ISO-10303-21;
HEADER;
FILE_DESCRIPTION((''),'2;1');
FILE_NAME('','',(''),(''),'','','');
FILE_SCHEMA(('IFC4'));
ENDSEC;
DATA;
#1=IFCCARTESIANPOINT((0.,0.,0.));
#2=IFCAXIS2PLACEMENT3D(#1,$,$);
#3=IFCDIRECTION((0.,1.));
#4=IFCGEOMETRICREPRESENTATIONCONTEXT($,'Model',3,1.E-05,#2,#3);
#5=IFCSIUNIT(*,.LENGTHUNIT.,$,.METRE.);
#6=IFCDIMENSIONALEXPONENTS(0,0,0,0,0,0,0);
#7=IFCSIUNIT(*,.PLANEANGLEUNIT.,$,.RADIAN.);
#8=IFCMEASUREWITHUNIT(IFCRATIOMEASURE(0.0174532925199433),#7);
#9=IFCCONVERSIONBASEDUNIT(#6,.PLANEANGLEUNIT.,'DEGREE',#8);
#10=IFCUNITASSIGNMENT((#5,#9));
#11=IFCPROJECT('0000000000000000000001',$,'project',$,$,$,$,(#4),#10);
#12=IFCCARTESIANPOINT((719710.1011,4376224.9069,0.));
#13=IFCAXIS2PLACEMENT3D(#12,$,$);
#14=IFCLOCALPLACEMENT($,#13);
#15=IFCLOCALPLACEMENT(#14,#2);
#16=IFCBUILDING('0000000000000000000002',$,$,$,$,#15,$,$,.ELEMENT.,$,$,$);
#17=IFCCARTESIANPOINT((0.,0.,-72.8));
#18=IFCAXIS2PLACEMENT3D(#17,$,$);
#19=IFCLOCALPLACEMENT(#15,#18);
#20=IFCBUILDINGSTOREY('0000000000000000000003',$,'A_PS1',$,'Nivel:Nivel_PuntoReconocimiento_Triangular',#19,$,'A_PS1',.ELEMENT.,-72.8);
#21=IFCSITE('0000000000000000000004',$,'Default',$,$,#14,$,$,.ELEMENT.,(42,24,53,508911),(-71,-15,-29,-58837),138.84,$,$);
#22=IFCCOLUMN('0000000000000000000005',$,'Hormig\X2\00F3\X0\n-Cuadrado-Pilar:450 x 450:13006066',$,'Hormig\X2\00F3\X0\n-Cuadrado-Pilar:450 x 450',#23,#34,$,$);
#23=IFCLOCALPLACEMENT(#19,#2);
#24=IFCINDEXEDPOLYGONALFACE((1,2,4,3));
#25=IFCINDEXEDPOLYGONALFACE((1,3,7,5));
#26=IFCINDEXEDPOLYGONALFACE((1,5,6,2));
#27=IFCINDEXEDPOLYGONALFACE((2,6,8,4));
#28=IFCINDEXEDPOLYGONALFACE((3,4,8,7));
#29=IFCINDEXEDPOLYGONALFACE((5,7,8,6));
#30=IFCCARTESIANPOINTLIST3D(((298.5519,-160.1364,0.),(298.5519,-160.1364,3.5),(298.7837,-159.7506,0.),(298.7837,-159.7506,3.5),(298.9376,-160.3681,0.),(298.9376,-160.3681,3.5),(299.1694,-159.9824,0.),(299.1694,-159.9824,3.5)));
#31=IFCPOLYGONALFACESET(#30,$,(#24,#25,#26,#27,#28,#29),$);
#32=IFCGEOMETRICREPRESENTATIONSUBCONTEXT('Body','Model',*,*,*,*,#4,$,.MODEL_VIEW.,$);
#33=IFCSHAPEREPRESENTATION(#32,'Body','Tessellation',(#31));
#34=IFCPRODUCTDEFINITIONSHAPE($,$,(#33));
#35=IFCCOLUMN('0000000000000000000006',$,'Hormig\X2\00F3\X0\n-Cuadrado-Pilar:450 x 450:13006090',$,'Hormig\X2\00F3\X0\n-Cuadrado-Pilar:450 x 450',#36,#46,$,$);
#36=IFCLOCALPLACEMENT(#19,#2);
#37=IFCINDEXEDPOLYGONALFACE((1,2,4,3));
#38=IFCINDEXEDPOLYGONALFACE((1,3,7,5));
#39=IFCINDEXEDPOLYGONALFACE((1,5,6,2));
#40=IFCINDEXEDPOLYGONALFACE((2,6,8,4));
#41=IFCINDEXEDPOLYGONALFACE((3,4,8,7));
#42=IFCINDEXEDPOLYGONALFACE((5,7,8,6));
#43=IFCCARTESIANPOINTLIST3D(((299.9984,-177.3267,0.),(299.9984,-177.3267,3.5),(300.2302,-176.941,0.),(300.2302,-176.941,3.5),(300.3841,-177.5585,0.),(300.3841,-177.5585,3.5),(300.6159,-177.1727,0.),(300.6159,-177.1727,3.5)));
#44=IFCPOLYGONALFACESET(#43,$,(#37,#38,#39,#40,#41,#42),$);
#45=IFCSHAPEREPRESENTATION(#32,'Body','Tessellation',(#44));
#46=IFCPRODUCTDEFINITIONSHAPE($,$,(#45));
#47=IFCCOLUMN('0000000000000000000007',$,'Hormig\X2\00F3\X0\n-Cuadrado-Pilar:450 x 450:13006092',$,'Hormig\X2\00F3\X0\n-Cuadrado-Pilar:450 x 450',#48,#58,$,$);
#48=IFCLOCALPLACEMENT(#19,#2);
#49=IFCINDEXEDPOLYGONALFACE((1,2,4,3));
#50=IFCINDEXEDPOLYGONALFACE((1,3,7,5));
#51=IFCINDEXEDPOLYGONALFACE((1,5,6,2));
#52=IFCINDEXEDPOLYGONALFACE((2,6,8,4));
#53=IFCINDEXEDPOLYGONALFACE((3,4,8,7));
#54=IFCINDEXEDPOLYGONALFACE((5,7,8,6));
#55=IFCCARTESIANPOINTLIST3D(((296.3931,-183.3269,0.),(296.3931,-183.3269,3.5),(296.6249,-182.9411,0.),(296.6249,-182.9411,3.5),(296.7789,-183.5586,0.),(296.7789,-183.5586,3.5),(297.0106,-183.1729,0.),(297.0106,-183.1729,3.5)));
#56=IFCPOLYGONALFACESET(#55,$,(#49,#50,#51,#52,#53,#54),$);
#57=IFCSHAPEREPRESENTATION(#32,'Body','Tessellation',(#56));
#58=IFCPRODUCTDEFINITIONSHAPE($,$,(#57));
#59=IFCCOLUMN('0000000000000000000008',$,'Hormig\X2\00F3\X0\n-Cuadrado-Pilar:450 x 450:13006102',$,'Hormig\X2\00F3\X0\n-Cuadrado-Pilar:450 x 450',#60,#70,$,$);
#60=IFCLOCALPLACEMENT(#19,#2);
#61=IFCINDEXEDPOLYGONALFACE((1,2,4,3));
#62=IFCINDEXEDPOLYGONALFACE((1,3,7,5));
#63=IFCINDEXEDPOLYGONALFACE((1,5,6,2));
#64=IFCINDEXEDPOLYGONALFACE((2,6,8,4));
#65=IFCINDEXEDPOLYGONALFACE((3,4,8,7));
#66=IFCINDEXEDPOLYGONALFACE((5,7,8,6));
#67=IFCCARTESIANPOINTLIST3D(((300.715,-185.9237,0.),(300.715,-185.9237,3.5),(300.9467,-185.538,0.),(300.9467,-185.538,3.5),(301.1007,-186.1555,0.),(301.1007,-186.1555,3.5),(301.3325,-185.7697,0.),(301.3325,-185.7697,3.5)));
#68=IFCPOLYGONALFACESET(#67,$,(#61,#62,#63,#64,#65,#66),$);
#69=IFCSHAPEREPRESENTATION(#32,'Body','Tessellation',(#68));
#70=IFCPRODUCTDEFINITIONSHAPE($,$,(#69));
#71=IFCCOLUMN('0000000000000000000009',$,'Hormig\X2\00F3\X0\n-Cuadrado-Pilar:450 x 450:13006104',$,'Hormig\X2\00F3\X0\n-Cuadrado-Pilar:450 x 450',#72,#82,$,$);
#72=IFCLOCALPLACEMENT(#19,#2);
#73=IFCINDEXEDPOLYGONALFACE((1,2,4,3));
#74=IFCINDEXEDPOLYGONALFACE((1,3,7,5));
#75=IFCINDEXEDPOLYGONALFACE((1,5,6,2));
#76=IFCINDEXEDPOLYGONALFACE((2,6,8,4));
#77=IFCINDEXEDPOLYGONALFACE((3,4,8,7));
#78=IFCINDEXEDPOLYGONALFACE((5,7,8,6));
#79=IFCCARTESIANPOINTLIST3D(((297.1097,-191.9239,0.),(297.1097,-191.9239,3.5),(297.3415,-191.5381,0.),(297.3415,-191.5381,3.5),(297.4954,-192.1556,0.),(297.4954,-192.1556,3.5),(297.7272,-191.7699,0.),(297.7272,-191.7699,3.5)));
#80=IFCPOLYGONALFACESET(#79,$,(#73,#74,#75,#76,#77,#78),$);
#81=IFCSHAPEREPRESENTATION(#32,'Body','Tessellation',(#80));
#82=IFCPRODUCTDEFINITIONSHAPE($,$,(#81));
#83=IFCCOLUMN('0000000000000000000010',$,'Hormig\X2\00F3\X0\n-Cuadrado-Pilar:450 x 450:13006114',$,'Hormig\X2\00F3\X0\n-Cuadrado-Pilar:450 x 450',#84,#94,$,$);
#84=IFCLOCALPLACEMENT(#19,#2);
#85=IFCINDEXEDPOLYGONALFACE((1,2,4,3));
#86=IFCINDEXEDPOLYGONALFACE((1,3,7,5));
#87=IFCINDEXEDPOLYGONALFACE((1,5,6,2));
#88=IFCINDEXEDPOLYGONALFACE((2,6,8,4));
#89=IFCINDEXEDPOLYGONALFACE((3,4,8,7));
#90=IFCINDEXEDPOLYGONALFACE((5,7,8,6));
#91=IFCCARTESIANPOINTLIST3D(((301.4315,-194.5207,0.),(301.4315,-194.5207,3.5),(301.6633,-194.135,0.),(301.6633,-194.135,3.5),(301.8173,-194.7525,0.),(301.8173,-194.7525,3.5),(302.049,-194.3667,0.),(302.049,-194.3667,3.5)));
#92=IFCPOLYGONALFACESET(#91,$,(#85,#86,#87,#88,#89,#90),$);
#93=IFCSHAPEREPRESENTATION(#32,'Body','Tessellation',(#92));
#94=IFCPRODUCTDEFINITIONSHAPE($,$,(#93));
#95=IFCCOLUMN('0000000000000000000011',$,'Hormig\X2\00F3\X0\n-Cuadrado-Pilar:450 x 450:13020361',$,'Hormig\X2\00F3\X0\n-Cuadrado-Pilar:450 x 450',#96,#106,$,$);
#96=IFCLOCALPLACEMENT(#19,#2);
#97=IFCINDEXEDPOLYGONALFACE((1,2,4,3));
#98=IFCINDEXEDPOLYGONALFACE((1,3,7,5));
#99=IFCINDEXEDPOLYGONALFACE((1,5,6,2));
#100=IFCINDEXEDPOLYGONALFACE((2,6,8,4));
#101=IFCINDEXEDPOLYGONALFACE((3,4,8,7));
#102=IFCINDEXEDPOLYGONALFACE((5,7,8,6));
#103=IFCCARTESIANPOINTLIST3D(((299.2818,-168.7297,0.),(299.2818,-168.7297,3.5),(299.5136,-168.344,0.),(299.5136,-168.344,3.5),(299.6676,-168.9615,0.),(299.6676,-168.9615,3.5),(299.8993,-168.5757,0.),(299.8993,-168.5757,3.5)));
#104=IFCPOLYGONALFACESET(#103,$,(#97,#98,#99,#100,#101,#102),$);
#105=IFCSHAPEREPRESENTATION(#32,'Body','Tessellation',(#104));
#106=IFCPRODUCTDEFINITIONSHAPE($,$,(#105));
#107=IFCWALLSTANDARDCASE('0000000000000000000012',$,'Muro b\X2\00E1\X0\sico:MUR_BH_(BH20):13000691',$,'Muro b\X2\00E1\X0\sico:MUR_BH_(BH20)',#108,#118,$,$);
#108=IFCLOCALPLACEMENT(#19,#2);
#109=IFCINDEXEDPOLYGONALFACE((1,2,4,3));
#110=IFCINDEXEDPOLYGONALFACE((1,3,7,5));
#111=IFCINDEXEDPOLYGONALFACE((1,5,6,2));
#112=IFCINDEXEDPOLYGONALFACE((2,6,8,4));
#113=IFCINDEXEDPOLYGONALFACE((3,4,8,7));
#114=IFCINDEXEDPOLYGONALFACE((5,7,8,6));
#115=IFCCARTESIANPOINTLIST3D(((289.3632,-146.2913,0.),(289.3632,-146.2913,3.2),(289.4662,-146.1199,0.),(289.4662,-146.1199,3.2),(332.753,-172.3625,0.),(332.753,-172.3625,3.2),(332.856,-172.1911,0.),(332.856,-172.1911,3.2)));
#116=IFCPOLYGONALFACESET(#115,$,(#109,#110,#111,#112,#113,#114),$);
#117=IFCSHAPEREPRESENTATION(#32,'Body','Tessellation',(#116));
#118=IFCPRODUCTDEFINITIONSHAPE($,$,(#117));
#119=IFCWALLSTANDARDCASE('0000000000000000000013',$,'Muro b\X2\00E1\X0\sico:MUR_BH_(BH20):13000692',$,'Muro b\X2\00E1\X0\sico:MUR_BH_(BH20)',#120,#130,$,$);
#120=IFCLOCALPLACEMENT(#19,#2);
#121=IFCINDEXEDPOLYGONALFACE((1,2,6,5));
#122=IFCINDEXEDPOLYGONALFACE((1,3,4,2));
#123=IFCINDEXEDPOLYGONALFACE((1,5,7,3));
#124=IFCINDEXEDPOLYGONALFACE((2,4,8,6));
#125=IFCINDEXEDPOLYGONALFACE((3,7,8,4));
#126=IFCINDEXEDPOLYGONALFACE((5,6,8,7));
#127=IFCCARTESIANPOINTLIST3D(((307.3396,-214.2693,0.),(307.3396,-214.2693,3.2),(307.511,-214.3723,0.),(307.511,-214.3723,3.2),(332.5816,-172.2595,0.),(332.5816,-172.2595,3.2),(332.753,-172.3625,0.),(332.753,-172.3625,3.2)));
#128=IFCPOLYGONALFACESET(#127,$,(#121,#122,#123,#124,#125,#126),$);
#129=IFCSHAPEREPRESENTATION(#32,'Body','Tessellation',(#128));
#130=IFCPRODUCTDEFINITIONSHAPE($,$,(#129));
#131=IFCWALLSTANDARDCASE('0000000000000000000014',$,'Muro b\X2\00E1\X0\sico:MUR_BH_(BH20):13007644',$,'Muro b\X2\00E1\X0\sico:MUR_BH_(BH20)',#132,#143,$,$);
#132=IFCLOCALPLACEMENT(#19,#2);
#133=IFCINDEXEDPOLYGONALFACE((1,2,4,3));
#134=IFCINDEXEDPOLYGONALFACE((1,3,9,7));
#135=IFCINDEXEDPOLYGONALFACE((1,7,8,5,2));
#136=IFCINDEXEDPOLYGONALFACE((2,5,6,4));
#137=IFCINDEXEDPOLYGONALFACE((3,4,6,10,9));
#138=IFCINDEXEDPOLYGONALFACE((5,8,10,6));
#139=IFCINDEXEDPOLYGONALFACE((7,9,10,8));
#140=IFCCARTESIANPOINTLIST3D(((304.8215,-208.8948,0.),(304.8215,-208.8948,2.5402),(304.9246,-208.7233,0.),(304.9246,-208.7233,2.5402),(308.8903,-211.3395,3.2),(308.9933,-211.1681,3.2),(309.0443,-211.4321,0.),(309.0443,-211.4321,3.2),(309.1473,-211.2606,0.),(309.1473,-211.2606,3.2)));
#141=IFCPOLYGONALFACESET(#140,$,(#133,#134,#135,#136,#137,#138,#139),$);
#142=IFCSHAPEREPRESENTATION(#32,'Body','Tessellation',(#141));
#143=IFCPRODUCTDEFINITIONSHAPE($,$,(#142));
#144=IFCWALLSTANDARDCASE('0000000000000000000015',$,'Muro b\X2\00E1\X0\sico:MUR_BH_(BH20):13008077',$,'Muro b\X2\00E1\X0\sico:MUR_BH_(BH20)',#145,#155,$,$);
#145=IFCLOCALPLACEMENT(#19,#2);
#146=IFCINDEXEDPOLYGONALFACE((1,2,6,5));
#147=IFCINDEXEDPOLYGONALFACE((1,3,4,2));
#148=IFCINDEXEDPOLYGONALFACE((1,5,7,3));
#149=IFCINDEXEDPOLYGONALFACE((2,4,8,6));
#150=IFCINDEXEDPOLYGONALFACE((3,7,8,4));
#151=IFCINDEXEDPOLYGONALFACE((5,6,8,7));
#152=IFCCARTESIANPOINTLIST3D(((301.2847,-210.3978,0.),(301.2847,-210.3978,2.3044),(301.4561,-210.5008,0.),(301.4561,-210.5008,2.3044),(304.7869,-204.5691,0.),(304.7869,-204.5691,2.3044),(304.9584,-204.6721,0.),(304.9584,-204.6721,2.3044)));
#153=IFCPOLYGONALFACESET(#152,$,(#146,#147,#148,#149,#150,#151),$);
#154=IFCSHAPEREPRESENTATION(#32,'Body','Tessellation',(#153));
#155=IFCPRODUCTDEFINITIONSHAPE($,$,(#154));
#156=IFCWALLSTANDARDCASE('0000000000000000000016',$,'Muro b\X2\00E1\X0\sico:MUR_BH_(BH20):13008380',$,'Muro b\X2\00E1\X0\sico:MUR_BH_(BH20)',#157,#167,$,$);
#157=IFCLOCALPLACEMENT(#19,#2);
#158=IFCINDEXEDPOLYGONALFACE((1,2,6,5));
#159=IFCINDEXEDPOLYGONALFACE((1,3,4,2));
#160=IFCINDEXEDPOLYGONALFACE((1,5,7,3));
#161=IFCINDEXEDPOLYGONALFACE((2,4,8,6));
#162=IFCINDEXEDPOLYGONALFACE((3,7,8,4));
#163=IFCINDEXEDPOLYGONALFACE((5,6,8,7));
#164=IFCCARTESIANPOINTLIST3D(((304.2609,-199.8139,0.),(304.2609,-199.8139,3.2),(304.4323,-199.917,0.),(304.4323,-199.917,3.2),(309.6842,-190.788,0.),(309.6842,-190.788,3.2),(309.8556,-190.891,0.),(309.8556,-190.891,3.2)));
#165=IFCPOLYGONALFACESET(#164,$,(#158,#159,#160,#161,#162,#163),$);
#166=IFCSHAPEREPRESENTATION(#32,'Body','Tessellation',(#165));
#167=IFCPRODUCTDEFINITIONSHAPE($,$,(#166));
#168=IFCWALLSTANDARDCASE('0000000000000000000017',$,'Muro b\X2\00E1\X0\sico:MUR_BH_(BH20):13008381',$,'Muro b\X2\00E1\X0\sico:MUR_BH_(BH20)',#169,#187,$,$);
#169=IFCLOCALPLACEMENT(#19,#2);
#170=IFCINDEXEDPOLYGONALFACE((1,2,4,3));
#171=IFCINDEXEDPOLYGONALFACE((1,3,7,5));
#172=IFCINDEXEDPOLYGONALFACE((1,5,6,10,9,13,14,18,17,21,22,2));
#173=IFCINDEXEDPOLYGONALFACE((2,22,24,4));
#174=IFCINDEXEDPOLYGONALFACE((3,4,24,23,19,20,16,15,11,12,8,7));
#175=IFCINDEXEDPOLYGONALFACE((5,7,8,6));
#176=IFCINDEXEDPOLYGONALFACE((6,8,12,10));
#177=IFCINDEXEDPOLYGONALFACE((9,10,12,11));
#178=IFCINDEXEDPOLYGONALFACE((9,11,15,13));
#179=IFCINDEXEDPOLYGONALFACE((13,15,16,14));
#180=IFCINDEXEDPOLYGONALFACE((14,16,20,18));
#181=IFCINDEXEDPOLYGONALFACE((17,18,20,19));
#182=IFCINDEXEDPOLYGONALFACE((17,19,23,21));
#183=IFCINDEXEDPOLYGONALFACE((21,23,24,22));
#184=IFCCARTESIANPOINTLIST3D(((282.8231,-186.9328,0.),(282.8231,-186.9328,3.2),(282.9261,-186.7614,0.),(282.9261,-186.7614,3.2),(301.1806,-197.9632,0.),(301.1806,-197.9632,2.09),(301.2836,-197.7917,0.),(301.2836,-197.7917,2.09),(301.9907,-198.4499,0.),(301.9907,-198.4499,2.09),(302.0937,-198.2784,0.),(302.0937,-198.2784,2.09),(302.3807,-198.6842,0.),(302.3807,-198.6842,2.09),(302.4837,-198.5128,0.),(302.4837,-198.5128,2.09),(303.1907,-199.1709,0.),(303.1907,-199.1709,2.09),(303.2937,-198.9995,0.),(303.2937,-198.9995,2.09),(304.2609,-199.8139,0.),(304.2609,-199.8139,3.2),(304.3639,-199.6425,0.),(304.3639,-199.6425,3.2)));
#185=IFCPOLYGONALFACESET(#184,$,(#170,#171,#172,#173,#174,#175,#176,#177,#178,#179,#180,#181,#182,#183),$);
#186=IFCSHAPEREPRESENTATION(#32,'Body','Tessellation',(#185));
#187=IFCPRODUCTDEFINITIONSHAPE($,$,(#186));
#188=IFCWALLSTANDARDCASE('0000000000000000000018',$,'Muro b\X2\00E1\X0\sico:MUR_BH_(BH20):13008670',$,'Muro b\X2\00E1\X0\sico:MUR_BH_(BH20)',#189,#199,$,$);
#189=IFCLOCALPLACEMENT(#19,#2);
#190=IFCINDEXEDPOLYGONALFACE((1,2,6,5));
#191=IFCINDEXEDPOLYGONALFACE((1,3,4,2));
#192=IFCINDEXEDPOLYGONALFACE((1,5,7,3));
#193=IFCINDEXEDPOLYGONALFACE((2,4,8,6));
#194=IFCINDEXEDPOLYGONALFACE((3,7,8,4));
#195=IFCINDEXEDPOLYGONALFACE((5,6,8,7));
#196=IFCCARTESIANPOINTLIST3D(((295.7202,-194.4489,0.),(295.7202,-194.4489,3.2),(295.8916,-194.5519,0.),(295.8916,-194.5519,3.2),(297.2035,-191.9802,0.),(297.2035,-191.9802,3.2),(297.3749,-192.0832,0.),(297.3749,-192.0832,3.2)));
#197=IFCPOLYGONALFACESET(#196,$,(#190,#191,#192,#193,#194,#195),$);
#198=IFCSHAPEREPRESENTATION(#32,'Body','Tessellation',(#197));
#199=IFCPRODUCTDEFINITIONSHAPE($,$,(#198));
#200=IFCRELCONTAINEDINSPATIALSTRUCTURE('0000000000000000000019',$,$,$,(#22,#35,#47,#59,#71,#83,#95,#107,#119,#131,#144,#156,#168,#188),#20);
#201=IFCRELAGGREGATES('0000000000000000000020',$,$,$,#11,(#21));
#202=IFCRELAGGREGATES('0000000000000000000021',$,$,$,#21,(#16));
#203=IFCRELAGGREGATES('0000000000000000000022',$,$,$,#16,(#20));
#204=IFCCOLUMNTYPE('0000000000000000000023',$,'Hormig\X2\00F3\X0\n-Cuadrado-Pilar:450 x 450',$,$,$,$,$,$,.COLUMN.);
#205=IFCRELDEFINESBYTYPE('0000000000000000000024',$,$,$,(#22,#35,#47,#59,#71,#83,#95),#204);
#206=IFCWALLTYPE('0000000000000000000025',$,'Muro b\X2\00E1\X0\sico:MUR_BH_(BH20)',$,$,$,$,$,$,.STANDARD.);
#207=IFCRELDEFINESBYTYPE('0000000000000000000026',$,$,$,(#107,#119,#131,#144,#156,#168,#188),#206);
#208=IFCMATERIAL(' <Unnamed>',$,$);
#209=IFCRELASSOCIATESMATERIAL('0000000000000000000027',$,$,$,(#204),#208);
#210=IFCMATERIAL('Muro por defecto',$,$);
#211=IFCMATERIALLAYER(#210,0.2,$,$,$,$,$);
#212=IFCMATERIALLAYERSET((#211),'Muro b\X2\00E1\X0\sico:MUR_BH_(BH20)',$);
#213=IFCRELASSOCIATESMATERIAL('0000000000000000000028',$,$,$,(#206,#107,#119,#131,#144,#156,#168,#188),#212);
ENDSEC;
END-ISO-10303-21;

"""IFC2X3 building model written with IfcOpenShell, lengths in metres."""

from ifc_helpers import new_model, entity, si_unit, converted_unit, direction, frame, frame_2d, origin, origin_2d_with_axis, place, context, subcontext, project, spatial, rectangle, extrude, clip, halfspace, source, transform, mapped, material, layer, layer_set, layer_usage, type_object, type_shapes, element, save


model = new_model("IFC2X3")

# Units and contexts
model_context = context("Model", 3, precision=1e-05, world=origin(), true_north=direction((0.0, 1.0)))
body_context = subcontext(model_context, "Body", "Model", "MODEL_VIEW")
ifc_project = project(units=[si_unit("LENGTHUNIT", "METRE"), converted_unit("PLANEANGLEUNIT", "DEGREE", entity("IfcRatioMeasure", 0.0174532925199433), si_unit("PLANEANGLEUNIT", "RADIAN"), dimensions=[0, 0, 0, 0, 0, 0, 0])], contexts=[model_context])

# Site, building, storey
site_placement = place(None, frame((719710.1011, 4376224.9069, 0.0)))
site = spatial("IfcSite", under=ifc_project, at=site_placement, Name="Default", CompositionType="ELEMENT", RefLatitude=(42, 24, 53, 508911), RefLongitude=(-71, -15, -29, -58837), RefElevation=138.84)
building_placement = place(site_placement, origin())
building = spatial("IfcBuilding", under=site, at=building_placement, CompositionType="ELEMENT")
storey_placement = place(building_placement, frame((0.0, 0.0, -72.8)))
storey = spatial("IfcBuildingStorey", under=building, at=storey_placement, Name="A_PS1", ObjectType="Nivel:Nivel_PuntoReconocimiento_Triangular", LongName="A_PS1", CompositionType="ELEMENT", Elevation=-72.8)

# Columns
ifc_material_1 = material(Name=" <Unnamed>")
column_type = type_object("IfcColumnType", Name="Hormigón-Cuadrado-Pilar:450 x 450", PredefinedType="COLUMN", material=ifc_material_1)
shared_shape = source(origin(), body_context, "Body", "SweptSolid", [
    extrude(rectangle(XDim=0.45, YDim=0.45, at=origin_2d_with_axis()), frame((0.0, 0.0, -72.8), z_axis=(0.0, 0.0, 1.0), x_axis=(0.0, -1.0, 0.0)), (0.0, 0.0, 1.0), 3.5),
])
type_shapes(column_type, [shared_shape])
for number, where, z_axis, x_axis, name in (
    (1, (298.8607, -160.0594, 72.8), (0.0, 0.0, 1.0), (0.857167, -0.515038, 0.0), "Hormigón-Cuadrado-Pilar:450 x 450:13006066"),
    (2, (300.3071, -177.2497, 72.8), (0.0, 0.0, 1.0), (0.857167, -0.515038, 0.0), "Hormigón-Cuadrado-Pilar:450 x 450:13006090"),
    (3, (296.7019, -183.2499, 72.8), (0.0, 0.0, 1.0), (0.857167, -0.515038, 0.0), "Hormigón-Cuadrado-Pilar:450 x 450:13006092"),
    (4, (301.0237, -185.8467, 72.8), (0.0, 0.0, 1.0), (0.857167, -0.515038, 0.0), "Hormigón-Cuadrado-Pilar:450 x 450:13006102"),
    (5, (297.4184, -191.8469, 72.8), (0.0, 0.0, 1.0), (0.857167, -0.515038, 0.0), "Hormigón-Cuadrado-Pilar:450 x 450:13006104"),
    (6, (301.7403, -194.4437, 72.8), (0.0, 0.0, 1.0), (0.857167, -0.515038, 0.0), "Hormigón-Cuadrado-Pilar:450 x 450:13006114"),
    (7, (299.5906, -168.6527, 72.8), (0.0, 0.0, 1.0), (0.857167, -0.515038, 0.0), "Hormigón-Cuadrado-Pilar:450 x 450:13020361"),
):
    element("IfcColumn", number, at=place(storey_placement, frame(where, z_axis=z_axis, x_axis=x_axis)), inside=storey, type_object=column_type, Name=name, ObjectType="Hormigón-Cuadrado-Pilar:450 x 450", context=body_context, shape_type="MappedRepresentation", body=[
        mapped(shared_shape, transform((0.0, 0.0, 0.0), scale=1.0)),
    ])

# Walls
ifc_material_2 = material(Name="Muro por defecto")
ifc_layer = layer(ifc_material_2, 0.2)
ifc_layer_set = layer_set([ifc_layer], Name="Muro básico:MUR_BH_(BH20)")
ifc_layer_usage_1 = layer_usage(ifc_layer_set, "AXIS2", "NEGATIVE", 0.1)
wall_type = type_object("IfcWallType", Name="Muro básico:MUR_BH_(BH20)", PredefinedType="STANDARD", material=ifc_layer_set)
wall_1_placement = place(storey_placement, frame((332.8045, -172.2768, 0.0), z_axis=(0.0, 0.0, 1.0), x_axis=(-0.857167, 0.515038, 0.0)))
element("IfcWallStandardCase", 8, at=wall_1_placement, inside=storey, type_object=wall_type, material=ifc_layer_usage_1, Name="Muro básico:MUR_BH_(BH20):13000691", ObjectType="Muro básico:MUR_BH_(BH20)", context=body_context, shape_type="SweptSolid", body=[
    extrude(rectangle(XDim=50.62, YDim=0.2, at=frame_2d((25.31, 0.0), x_axis=(-1.0, 0.0))), origin(), (0.0, 0.0, 1.0), 3.2),
])
ifc_layer_usage_2 = layer_usage(ifc_layer_set, "AXIS2", "NEGATIVE", 0.1)
wall_2_placement = place(storey_placement, frame((332.6673, -172.311, 0.0), z_axis=(0.0, 0.0, 1.0), x_axis=(-0.515038, -0.857167, 0.0)))
element("IfcWallStandardCase", 9, at=wall_2_placement, inside=storey, type_object=wall_type, material=ifc_layer_usage_2, Name="Muro básico:MUR_BH_(BH20):13000692", ObjectType="Muro básico:MUR_BH_(BH20)", context=body_context, shape_type="SweptSolid", body=[
    extrude(rectangle(XDim=49.01, YDim=0.2, at=frame_2d((24.505, 0.0), x_axis=(-1.0, 0.0))), origin(), (0.0, 0.0, 1.0), 3.2),
])
ifc_layer_usage_3 = layer_usage(ifc_layer_set, "AXIS2", "NEGATIVE", 0.1)
wall_3_placement = place(storey_placement, frame((304.8731, -208.809, 0.0), z_axis=(0.0, 0.0, 1.0), x_axis=(0.857167, -0.515038, 0.0)))
element("IfcWallStandardCase", 10, at=wall_3_placement, inside=storey, type_object=wall_type, material=ifc_layer_usage_3, Name="Muro básico:MUR_BH_(BH20):13007644", ObjectType="Muro básico:MUR_BH_(BH20)", context=body_context, shape_type="Clipping", body=[
    clip(extrude(rectangle(XDim=4.9264, YDim=0.2, at=frame_2d((2.4632, 0.0), x_axis=(-1.0, 0.0))), origin(), (0.0, 0.0, 1.0), 3.2), halfspace(frame((0.0, -0.1, 2.5402), z_axis=(-0.137686, 0.0, 0.990476), x_axis=(0.0, 1.0, 0.0)), False)),
])
ifc_layer_usage_4 = layer_usage(ifc_layer_set, "AXIS2", "NEGATIVE", 0.1)
wall_4_placement = place(storey_placement, frame((304.8726, -204.6206, 0.0), z_axis=(0.0, 0.0, 1.0), x_axis=(-0.515038, -0.857167, 0.0)))
element("IfcWallStandardCase", 11, at=wall_4_placement, inside=storey, type_object=wall_type, material=ifc_layer_usage_4, Name="Muro básico:MUR_BH_(BH20):13008077", ObjectType="Muro básico:MUR_BH_(BH20)", context=body_context, shape_type="SweptSolid", body=[
    extrude(rectangle(XDim=6.8, YDim=0.2, at=frame_2d((3.4, 0.0), x_axis=(-1.0, 0.0))), origin(), (0.0, 0.0, 1.0), 2.3044),
])

# Wall
ifc_layer_usage_5 = layer_usage(ifc_layer_set, "AXIS2", "NEGATIVE", 0.1)
wall_5_placement = place(storey_placement, frame((309.7699, -190.8395, 0.0), z_axis=(0.0, 0.0, 1.0), x_axis=(-0.515038, -0.857167, 0.0)))
element("IfcWallStandardCase", 12, at=wall_5_placement, inside=storey, type_object=wall_type, material=ifc_layer_usage_5, Name="Muro básico:MUR_BH_(BH20):13008380", ObjectType="Muro básico:MUR_BH_(BH20)", context=body_context, shape_type="SweptSolid", body=[
    extrude(rectangle(XDim=10.53, YDim=0.2, at=frame_2d((5.265, 0.0), x_axis=(-1.0, 0.0))), origin(), (0.0, 0.0, 1.0), 3.2),
])

# Wall, openings
ifc_layer_usage_6 = layer_usage(ifc_layer_set, "AXIS2", "NEGATIVE", 0.1)
wall_6_placement = place(storey_placement, frame((304.3124, -199.7282, 0.0), z_axis=(0.0, 0.0, 1.0), x_axis=(-0.857167, 0.515038, 0.0)))
wall_6 = element("IfcWallStandardCase", 13, at=wall_6_placement, inside=storey, type_object=wall_type, material=ifc_layer_usage_6, Name="Muro básico:MUR_BH_(BH20):13008381", ObjectType="Muro básico:MUR_BH_(BH20)", context=body_context, shape_type="SweptSolid", body=[
    extrude(rectangle(XDim=25.01, YDim=0.2, at=frame_2d((12.505, 0.0), x_axis=(-1.0, 0.0))), origin(), (0.0, 0.0, 1.0), 3.2),
])
opening_1_placement = place(wall_6_placement, frame((363.7142, -14.468, 0.0), z_axis=(0.0, 0.0, 1.0), x_axis=(-0.857167, -0.515038, 0.0)))
element("IfcOpeningElement", 14, at=opening_1_placement, cuts=wall_6, ObjectType="Opening", context=body_context, shape_type="SweptSolid", body=[
    extrude(rectangle(XDim=2.09, YDim=0.945, at=frame_2d((0.0, 0.0), x_axis=(0.0, 1.0))), frame((301.6887, -198.0351, 1.045), z_axis=(-0.515038, -0.857167, 0.0), x_axis=(-0.857167, 0.515038, 0.0)), (0.0, 0.0, 1.0), 0.2),
])
opening_2_placement = place(wall_6_placement, frame((363.7142, -14.468, 0.0), z_axis=(0.0, 0.0, 1.0), x_axis=(-0.857167, -0.515038, 0.0)))
element("IfcOpeningElement", 15, at=opening_2_placement, cuts=wall_6, ObjectType="Opening", context=body_context, shape_type="SweptSolid", body=[
    extrude(rectangle(XDim=2.09, YDim=0.945, at=frame_2d((0.0, 0.0), x_axis=(1.0, 0.0))), frame((302.8887, -198.7561, 1.045), z_axis=(-0.515038, -0.857167, 0.0), x_axis=(0.0, 0.0, -1.0)), (0.0, 0.0, 1.0), 0.2),
])

# Wall
ifc_layer_usage_7 = layer_usage(ifc_layer_set, "AXIS2", "NEGATIVE", 0.1)
wall_7_placement = place(storey_placement, frame((297.2892, -192.0317, 0.0), z_axis=(0.0, 0.0, 1.0), x_axis=(-0.515038, -0.857167, 0.0)))
element("IfcWallStandardCase", 16, at=wall_7_placement, inside=storey, type_object=wall_type, material=ifc_layer_usage_7, Name="Muro básico:MUR_BH_(BH20):13008670", ObjectType="Muro básico:MUR_BH_(BH20)", context=body_context, shape_type="SweptSolid", body=[
    extrude(rectangle(XDim=2.88, YDim=0.2, at=frame_2d((1.44, 0.0), x_axis=(-1.0, 0.0))), origin(), (0.0, 0.0, 1.0), 3.2),
])

save(model, "model.ifc")
